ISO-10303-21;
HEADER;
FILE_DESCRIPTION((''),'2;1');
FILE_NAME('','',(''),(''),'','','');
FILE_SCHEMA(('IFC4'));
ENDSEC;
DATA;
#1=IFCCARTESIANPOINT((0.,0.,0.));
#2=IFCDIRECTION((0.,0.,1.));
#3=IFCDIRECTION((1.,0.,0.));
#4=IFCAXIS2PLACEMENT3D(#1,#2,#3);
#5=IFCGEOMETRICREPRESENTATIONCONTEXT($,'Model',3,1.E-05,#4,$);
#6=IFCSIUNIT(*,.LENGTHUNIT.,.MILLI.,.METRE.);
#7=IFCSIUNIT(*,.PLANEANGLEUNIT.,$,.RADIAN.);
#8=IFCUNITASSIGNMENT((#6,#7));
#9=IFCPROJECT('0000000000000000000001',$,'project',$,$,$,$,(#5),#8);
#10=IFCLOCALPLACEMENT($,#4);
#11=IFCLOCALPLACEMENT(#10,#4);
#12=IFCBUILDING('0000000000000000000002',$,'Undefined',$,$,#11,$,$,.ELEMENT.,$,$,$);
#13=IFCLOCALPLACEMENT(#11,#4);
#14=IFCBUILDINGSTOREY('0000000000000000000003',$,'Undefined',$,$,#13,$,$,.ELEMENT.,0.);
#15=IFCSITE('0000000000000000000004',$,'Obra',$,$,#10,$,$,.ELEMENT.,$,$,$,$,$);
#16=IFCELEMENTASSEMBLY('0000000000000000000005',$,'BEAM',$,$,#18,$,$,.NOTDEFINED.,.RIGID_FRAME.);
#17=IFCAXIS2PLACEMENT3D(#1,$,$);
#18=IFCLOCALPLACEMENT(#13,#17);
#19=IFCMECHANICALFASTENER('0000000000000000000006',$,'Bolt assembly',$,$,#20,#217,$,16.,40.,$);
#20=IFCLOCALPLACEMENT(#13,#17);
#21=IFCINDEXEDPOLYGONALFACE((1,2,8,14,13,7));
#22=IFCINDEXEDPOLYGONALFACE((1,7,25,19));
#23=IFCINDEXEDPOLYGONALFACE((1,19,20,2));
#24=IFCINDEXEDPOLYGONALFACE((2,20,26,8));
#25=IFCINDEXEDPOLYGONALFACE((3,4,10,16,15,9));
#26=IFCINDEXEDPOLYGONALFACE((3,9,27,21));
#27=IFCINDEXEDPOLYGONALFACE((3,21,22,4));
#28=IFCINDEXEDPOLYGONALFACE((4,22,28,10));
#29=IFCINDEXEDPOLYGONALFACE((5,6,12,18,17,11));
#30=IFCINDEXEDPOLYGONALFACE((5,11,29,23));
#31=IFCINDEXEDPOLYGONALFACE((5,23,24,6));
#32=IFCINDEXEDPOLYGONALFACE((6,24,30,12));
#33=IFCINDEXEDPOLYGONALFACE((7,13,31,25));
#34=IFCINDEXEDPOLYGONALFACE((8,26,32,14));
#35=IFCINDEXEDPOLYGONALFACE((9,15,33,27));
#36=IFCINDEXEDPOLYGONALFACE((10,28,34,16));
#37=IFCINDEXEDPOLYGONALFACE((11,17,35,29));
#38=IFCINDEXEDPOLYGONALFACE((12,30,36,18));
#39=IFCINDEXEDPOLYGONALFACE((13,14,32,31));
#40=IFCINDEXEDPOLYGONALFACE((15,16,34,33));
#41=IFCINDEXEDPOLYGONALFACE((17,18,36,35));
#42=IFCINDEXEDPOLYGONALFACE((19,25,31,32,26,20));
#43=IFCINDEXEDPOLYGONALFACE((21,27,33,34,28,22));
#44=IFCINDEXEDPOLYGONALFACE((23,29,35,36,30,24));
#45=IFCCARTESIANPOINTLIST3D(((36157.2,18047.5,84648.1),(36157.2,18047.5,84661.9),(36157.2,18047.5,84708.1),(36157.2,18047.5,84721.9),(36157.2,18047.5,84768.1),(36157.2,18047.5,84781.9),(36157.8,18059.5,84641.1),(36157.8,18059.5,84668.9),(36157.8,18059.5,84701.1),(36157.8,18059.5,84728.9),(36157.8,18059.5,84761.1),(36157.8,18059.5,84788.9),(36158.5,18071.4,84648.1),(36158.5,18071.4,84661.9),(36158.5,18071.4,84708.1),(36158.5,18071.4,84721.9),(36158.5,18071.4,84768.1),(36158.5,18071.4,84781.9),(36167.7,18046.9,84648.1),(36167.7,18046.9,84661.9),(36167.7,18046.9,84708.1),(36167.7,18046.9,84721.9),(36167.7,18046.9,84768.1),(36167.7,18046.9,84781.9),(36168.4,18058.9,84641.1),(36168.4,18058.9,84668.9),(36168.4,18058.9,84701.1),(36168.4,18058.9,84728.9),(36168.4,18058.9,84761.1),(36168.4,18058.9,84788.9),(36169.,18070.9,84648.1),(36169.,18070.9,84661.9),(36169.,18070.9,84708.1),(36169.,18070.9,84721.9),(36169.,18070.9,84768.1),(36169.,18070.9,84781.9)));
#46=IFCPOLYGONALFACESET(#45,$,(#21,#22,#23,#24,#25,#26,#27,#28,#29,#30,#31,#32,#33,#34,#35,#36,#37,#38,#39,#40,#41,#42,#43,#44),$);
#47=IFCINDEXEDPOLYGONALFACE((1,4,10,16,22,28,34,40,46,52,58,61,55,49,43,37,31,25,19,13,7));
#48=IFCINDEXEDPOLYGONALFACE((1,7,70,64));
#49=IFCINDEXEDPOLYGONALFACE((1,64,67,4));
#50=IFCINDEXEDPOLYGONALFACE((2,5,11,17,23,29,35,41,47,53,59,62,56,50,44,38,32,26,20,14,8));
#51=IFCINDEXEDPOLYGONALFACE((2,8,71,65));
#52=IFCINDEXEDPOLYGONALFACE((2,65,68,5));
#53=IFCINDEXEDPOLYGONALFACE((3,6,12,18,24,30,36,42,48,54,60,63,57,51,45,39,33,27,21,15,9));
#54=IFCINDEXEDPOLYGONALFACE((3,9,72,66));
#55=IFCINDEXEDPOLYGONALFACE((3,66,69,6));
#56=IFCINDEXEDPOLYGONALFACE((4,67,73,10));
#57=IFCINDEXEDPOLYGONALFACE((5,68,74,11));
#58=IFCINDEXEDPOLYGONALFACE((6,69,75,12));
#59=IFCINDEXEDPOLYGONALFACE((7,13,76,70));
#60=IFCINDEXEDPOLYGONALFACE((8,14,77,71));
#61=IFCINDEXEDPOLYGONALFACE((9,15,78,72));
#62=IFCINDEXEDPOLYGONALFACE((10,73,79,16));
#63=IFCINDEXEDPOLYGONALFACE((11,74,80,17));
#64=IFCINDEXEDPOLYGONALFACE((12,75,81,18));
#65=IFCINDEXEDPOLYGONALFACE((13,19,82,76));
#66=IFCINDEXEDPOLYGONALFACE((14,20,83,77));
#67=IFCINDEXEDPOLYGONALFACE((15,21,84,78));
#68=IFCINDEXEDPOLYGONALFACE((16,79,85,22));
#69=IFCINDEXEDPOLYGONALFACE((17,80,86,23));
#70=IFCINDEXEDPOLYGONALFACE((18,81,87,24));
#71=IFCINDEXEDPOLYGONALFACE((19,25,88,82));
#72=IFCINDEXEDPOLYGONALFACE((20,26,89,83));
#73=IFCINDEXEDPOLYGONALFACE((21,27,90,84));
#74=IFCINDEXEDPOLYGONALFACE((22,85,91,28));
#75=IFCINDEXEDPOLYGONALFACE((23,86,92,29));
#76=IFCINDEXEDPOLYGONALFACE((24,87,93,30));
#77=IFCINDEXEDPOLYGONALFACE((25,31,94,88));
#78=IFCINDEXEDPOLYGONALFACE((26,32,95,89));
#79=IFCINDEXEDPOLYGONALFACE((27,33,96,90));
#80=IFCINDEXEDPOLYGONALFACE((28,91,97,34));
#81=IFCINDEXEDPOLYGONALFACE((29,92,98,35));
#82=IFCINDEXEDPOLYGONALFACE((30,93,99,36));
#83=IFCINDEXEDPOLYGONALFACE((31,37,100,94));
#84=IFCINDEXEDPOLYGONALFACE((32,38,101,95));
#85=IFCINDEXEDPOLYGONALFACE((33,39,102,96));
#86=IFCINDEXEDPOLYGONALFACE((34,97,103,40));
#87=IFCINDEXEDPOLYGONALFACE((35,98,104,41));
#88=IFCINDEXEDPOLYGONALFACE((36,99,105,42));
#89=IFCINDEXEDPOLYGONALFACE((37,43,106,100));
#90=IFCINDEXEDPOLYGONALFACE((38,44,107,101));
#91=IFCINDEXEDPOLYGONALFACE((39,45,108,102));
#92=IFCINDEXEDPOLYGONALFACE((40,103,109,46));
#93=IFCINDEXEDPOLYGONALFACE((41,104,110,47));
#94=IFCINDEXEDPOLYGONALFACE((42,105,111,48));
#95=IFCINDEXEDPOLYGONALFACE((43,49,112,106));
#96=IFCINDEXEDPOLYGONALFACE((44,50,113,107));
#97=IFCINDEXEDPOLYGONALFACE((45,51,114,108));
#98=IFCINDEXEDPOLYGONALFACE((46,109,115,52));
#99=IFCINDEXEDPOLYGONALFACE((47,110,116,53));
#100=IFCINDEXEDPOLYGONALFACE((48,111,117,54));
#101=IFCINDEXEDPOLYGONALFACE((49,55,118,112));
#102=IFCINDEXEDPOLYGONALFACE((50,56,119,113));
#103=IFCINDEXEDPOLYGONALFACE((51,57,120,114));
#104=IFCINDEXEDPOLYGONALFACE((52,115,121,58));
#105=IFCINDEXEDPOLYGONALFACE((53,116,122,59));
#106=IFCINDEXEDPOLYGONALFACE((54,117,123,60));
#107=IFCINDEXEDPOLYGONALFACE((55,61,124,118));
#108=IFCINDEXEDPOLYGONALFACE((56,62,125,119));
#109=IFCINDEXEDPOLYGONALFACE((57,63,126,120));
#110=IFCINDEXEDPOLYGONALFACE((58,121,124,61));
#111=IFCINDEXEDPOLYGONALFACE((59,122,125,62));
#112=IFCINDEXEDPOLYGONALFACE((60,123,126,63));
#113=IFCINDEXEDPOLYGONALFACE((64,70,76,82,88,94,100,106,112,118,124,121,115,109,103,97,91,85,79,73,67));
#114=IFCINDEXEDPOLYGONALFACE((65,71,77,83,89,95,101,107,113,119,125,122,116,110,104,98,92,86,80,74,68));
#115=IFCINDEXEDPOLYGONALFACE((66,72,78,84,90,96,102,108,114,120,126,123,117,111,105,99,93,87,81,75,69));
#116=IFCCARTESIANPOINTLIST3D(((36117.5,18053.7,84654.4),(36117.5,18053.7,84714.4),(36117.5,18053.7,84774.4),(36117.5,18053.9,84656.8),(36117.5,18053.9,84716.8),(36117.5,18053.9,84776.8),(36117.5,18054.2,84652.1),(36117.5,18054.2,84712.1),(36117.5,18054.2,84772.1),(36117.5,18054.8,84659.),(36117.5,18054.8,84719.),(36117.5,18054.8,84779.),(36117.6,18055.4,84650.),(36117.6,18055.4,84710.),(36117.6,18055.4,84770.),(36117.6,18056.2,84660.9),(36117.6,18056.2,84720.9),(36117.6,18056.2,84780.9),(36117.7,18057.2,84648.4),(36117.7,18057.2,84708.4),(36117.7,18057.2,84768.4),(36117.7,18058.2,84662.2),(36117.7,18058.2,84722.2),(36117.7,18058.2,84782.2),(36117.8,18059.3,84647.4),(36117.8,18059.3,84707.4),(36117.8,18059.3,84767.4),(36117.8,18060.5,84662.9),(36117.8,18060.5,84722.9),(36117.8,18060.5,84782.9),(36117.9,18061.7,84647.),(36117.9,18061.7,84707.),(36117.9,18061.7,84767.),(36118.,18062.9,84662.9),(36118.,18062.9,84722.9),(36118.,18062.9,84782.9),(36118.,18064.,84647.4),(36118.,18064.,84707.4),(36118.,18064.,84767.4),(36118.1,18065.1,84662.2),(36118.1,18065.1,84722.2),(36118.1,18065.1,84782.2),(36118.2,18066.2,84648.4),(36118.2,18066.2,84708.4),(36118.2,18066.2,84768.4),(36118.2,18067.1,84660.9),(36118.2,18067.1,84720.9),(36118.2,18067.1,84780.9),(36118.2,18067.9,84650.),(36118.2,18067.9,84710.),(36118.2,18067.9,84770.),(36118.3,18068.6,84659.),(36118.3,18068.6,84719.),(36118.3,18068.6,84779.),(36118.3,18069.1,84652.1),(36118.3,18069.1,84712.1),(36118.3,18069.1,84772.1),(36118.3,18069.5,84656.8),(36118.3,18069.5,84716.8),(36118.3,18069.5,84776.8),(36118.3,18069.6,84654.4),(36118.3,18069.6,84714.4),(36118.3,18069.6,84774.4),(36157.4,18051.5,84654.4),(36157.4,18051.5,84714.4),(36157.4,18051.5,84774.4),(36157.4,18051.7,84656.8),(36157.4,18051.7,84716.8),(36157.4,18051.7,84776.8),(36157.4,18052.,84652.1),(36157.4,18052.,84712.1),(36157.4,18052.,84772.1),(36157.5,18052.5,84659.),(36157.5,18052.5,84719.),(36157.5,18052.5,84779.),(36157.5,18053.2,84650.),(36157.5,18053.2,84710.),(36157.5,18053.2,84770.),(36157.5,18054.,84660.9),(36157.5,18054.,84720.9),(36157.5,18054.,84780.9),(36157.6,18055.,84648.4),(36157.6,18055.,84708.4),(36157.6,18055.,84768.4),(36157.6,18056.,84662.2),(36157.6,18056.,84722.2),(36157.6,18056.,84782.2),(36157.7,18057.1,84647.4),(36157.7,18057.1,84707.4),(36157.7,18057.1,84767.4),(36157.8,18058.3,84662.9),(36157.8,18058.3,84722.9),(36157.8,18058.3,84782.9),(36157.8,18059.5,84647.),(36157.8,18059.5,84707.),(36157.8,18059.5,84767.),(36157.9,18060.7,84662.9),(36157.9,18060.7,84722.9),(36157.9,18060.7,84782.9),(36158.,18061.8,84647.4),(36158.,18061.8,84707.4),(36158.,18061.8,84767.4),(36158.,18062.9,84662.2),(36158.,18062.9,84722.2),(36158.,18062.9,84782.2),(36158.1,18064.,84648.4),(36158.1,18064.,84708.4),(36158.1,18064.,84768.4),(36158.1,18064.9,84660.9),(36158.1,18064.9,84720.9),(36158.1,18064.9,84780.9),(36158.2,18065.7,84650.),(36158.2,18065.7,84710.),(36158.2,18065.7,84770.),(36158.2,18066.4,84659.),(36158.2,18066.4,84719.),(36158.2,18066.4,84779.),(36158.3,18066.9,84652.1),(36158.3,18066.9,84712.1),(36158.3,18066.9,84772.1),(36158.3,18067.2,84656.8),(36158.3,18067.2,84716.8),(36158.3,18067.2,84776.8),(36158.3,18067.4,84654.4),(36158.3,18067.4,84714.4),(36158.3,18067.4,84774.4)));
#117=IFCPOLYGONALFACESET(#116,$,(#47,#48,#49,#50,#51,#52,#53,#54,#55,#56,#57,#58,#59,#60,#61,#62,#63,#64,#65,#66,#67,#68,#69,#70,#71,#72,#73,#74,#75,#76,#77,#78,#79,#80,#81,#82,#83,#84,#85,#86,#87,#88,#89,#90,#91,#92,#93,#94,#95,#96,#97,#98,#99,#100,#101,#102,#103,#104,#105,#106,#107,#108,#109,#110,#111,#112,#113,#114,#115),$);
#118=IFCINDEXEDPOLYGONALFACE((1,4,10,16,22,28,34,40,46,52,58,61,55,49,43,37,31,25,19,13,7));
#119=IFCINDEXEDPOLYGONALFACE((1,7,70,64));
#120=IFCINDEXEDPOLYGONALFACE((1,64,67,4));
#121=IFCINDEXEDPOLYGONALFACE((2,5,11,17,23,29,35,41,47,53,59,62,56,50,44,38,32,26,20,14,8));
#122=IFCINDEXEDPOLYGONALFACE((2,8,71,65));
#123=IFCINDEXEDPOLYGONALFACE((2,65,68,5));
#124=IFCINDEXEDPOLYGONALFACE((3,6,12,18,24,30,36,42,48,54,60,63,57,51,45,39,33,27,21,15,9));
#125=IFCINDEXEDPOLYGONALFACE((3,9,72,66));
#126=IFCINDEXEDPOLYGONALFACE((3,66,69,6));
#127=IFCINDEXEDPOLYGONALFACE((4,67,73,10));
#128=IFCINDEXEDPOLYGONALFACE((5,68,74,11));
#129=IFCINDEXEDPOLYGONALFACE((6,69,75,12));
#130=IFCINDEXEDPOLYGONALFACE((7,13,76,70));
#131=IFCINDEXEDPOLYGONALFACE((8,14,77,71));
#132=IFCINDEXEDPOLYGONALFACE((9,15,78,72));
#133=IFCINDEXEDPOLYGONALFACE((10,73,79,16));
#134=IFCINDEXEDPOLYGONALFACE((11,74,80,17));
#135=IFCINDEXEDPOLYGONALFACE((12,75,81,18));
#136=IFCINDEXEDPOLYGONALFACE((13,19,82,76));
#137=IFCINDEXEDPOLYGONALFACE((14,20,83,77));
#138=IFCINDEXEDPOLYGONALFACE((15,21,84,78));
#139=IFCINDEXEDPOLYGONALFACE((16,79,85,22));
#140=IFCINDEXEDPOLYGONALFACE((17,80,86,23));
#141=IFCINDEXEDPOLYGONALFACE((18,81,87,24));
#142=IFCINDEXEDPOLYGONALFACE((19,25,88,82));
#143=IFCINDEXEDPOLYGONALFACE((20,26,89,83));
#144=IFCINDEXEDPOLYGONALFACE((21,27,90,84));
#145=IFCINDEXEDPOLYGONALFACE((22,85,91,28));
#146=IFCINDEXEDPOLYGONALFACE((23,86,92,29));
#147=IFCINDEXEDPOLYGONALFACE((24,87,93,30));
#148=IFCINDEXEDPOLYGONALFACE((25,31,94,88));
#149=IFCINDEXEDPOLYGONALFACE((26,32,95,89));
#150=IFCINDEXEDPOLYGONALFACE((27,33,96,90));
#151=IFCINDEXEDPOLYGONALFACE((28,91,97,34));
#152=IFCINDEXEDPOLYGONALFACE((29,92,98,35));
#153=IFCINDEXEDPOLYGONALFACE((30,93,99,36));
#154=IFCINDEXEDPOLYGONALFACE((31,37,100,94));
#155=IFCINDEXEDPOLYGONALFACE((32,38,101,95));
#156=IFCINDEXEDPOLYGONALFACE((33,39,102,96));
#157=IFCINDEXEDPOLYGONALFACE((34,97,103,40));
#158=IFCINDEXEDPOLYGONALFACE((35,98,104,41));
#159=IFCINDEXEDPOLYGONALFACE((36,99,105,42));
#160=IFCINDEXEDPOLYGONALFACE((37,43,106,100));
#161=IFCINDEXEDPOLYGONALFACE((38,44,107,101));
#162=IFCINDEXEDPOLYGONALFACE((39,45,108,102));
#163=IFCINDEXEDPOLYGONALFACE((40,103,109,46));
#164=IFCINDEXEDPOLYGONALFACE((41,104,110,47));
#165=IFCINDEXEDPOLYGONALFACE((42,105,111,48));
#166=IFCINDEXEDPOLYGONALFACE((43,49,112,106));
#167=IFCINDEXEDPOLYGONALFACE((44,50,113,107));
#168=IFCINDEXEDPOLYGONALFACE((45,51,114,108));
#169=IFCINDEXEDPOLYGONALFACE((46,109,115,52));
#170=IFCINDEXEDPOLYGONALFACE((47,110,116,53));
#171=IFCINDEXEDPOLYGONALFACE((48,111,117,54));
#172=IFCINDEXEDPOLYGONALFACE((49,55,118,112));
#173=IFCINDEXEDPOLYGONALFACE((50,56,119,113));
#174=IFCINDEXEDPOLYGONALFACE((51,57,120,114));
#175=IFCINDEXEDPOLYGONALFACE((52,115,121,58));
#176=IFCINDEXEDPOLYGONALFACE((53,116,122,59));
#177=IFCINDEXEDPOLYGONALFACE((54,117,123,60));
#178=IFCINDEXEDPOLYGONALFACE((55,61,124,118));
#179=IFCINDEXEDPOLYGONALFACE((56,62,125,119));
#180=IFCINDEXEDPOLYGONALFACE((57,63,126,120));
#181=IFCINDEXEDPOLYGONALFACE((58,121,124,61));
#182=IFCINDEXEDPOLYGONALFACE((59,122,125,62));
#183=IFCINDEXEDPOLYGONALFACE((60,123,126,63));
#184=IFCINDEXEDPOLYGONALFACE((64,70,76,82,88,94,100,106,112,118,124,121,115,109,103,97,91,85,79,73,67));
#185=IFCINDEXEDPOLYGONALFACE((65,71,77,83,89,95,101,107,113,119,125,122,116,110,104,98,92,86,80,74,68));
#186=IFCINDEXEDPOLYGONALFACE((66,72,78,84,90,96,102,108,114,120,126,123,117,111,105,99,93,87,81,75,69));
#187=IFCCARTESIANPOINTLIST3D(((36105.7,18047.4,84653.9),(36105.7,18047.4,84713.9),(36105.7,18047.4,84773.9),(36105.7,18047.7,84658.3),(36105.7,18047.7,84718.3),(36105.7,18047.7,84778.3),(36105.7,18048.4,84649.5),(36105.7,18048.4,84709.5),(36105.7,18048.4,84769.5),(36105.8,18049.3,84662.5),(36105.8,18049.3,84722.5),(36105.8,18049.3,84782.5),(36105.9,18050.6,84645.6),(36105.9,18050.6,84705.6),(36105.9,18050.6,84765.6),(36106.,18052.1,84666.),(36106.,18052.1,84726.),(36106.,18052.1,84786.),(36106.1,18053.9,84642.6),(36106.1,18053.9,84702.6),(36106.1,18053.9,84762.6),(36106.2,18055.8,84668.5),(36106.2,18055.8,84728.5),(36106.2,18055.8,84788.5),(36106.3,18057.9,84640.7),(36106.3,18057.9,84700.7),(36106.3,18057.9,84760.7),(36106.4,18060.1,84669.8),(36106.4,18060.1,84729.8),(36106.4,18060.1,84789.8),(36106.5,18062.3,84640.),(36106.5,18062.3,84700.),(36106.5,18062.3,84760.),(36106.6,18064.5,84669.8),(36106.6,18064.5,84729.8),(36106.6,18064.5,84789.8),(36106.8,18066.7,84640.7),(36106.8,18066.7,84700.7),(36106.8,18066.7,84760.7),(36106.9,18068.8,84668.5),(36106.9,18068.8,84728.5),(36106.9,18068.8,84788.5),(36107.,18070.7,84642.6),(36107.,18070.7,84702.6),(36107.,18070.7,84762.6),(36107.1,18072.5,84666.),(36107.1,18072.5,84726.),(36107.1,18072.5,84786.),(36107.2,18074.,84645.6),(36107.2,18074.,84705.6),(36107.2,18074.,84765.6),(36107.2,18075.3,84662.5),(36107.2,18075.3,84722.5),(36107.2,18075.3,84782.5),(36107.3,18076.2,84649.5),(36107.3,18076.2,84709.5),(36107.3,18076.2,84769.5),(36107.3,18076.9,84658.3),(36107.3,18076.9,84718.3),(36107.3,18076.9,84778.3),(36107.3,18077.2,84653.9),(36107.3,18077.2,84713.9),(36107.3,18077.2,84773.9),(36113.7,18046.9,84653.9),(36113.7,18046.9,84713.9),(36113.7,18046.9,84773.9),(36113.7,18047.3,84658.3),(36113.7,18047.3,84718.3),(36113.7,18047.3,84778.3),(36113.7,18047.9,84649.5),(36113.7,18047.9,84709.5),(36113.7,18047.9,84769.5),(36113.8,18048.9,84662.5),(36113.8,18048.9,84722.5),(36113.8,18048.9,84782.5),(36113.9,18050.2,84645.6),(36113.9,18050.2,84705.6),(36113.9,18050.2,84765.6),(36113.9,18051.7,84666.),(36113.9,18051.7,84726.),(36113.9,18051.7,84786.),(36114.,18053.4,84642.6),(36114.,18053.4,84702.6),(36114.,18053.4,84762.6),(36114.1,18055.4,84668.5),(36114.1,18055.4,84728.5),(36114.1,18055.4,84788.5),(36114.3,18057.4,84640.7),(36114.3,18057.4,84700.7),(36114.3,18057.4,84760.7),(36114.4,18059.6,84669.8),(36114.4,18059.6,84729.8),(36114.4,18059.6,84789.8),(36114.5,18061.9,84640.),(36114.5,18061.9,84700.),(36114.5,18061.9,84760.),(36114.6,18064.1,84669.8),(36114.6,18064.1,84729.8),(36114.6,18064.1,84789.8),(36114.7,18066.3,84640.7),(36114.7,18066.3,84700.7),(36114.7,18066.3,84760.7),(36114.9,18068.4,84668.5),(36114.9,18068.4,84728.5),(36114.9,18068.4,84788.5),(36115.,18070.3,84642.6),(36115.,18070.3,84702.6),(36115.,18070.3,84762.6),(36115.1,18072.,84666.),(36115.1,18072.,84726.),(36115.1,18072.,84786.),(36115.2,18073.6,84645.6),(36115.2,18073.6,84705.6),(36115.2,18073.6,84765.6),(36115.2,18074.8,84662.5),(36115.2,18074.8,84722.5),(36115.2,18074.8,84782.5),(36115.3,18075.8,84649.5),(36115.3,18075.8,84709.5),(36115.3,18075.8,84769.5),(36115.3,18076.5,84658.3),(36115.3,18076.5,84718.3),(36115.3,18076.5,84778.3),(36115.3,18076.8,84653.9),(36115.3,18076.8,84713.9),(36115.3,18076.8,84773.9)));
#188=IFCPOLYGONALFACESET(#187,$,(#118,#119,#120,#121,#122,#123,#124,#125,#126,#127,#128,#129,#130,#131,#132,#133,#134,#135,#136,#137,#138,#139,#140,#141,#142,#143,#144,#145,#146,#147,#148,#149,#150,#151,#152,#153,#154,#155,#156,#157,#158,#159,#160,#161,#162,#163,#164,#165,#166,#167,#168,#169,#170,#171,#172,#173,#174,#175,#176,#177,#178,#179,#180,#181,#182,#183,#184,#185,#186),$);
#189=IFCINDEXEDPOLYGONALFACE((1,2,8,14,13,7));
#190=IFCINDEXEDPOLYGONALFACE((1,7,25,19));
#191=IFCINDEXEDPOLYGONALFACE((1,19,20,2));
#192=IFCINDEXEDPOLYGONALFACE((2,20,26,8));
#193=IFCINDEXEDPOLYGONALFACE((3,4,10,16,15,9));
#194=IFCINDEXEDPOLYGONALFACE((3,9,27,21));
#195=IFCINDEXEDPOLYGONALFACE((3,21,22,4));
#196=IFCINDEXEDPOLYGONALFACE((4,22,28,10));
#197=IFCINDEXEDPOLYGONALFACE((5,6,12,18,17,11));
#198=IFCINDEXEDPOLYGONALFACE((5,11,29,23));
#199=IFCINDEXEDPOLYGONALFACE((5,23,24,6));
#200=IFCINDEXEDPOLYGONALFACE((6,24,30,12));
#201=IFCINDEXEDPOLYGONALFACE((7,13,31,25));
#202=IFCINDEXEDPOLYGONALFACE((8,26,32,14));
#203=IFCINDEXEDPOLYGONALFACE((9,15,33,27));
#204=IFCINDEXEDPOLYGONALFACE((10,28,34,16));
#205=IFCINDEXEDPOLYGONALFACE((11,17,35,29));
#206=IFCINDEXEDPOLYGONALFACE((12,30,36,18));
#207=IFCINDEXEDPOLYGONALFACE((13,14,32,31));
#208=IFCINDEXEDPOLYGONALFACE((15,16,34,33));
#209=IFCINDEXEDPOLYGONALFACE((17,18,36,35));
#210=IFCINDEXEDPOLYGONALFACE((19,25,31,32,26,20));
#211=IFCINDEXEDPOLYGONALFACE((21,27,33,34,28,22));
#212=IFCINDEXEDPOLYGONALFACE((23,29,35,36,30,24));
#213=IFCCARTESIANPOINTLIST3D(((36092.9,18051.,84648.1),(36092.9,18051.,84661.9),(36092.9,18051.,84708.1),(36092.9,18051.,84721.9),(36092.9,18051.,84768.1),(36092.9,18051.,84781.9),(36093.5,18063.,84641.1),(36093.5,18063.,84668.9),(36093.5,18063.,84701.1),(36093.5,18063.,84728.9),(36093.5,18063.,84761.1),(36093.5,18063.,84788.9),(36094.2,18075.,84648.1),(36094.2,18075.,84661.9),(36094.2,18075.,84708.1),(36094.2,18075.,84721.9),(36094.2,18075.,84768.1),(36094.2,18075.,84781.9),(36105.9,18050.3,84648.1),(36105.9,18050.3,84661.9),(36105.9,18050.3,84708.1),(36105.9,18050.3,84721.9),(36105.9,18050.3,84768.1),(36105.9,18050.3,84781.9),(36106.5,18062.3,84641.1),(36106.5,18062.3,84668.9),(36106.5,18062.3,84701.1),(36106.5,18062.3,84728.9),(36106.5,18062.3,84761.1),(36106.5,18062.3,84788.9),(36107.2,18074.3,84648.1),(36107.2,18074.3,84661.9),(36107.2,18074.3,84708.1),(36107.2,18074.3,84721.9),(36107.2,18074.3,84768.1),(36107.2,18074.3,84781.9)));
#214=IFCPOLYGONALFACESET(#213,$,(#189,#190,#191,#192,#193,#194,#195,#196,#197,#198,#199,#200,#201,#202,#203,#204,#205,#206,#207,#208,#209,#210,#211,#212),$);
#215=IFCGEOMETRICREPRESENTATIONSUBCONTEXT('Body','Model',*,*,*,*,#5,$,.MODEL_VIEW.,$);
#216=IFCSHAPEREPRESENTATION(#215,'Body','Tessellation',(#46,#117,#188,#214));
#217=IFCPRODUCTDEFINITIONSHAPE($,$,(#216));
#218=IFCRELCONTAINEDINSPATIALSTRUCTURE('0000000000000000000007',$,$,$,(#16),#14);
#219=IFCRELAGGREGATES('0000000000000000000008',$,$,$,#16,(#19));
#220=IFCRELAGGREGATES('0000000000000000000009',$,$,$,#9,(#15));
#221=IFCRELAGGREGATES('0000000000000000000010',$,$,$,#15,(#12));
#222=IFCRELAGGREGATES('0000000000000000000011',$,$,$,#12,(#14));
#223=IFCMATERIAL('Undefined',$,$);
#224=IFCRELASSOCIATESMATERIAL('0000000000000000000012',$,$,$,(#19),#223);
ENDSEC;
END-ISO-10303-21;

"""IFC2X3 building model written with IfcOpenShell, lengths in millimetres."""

from ifc_helpers import new_model, si_unit, frame, origin_with_axes, origin_2d_with_axis, place, context, subcontext, project, spatial, polyline, circle, outline, extrude, source, transform, mapped, material, element, aggregate, save


model = new_model("IFC2X3")

# Units and contexts
model_context = context("Model", 3, precision=1e-05, world=origin_with_axes())
body_context = subcontext(model_context, "Body", "Model", "MODEL_VIEW")
ifc_project = project(units=[si_unit("LENGTHUNIT", "METRE", prefix="MILLI"), si_unit("PLANEANGLEUNIT", "RADIAN")], contexts=[model_context])

# Site, building, storey
site_placement = place(None, origin_with_axes())
site = spatial("IfcSite", under=ifc_project, at=site_placement, Name="Obra", CompositionType="ELEMENT")
building_placement = place(site_placement, origin_with_axes())
building = spatial("IfcBuilding", under=site, at=building_placement, Name="Undefined", CompositionType="ELEMENT")
storey_placement = place(building_placement, origin_with_axes())
storey = spatial("IfcBuildingStorey", under=building, at=storey_placement, Name="Undefined", CompositionType="ELEMENT", Elevation=0.0)

# Element assembly, mechanical fastener
assembly_1_placement = place(storey_placement, origin_with_axes())
assembly_1 = element("IfcElementAssembly", 1, at=assembly_1_placement, inside=storey, Name="BEAM", AssemblyPlace="NOTDEFINED", PredefinedType="RIGID_FRAME")
ifc_material_1 = material(Name="Undefined")
shared_shape_1 = source(origin_with_axes(), body_context, "Body", "SweptSolid", [
    extrude(outline(polyline([(13.9, 0.0), (6.9, 12.0), (-6.9, 12.0), (-13.9, 0.0), (-6.9, -12.0), (6.9, -12.0), (13.9, 0.0)])), frame((0.0, -19.7, 0.0), z_axis=(0.0, 1.0, 0.0), x_axis=(1.0, 0.0, 0.0)), (0.0, 0.0, 1.0), 10.6),
    extrude(circle(Radius=8.0, at=origin_2d_with_axis()), frame((0.0, -9.1, 0.0), z_axis=(0.0, 1.0, 0.0), x_axis=(1.0, 0.0, 0.0)), (0.0, 0.0, 1.0), 40.0),
    extrude(circle(Radius=15.0, at=origin_2d_with_axis()), frame((0.0, 34.3, 0.0), z_axis=(0.0, 1.0, 0.0), x_axis=(1.0, 0.0, 0.0)), (0.0, 0.0, 1.0), 8.0),
    extrude(outline(polyline([(13.9, 0.0), (6.9, 12.0), (-6.9, 12.0), (-13.9, 0.0), (-6.9, -12.0), (6.9, -12.0), (13.9, 0.0)])), frame((0.0, 42.3, 0.0), z_axis=(0.0, 1.0, 0.0), x_axis=(1.0, 0.0, 0.0)), (0.0, 0.0, 1.0), 13.0),
])
mechanical_fastener_1_placement = place(assembly_1_placement, frame((36146.0, 18010.0, 84835.0), z_axis=(0.055268, 0.998472, 0.0), x_axis=(0.0, 0.0, -1.0)))
mechanical_fastener_1 = element("IfcMechanicalFastener", 2, at=mechanical_fastener_1_placement, material=ifc_material_1, Name="Bolt assembly", NominalDiameter=16.0, NominalLength=40.0, context=body_context, shape_type="MappedRepresentation", body=[
    mapped(shared_shape_1, transform((60.0, 0.0, 50.0))),
    mapped(shared_shape_1, transform((120.0, 0.0, 50.0))),
    mapped(shared_shape_1, transform((180.0, 0.0, 50.0))),
])

aggregate(assembly_1, [mechanical_fastener_1])

save(model, "model.ifc")
